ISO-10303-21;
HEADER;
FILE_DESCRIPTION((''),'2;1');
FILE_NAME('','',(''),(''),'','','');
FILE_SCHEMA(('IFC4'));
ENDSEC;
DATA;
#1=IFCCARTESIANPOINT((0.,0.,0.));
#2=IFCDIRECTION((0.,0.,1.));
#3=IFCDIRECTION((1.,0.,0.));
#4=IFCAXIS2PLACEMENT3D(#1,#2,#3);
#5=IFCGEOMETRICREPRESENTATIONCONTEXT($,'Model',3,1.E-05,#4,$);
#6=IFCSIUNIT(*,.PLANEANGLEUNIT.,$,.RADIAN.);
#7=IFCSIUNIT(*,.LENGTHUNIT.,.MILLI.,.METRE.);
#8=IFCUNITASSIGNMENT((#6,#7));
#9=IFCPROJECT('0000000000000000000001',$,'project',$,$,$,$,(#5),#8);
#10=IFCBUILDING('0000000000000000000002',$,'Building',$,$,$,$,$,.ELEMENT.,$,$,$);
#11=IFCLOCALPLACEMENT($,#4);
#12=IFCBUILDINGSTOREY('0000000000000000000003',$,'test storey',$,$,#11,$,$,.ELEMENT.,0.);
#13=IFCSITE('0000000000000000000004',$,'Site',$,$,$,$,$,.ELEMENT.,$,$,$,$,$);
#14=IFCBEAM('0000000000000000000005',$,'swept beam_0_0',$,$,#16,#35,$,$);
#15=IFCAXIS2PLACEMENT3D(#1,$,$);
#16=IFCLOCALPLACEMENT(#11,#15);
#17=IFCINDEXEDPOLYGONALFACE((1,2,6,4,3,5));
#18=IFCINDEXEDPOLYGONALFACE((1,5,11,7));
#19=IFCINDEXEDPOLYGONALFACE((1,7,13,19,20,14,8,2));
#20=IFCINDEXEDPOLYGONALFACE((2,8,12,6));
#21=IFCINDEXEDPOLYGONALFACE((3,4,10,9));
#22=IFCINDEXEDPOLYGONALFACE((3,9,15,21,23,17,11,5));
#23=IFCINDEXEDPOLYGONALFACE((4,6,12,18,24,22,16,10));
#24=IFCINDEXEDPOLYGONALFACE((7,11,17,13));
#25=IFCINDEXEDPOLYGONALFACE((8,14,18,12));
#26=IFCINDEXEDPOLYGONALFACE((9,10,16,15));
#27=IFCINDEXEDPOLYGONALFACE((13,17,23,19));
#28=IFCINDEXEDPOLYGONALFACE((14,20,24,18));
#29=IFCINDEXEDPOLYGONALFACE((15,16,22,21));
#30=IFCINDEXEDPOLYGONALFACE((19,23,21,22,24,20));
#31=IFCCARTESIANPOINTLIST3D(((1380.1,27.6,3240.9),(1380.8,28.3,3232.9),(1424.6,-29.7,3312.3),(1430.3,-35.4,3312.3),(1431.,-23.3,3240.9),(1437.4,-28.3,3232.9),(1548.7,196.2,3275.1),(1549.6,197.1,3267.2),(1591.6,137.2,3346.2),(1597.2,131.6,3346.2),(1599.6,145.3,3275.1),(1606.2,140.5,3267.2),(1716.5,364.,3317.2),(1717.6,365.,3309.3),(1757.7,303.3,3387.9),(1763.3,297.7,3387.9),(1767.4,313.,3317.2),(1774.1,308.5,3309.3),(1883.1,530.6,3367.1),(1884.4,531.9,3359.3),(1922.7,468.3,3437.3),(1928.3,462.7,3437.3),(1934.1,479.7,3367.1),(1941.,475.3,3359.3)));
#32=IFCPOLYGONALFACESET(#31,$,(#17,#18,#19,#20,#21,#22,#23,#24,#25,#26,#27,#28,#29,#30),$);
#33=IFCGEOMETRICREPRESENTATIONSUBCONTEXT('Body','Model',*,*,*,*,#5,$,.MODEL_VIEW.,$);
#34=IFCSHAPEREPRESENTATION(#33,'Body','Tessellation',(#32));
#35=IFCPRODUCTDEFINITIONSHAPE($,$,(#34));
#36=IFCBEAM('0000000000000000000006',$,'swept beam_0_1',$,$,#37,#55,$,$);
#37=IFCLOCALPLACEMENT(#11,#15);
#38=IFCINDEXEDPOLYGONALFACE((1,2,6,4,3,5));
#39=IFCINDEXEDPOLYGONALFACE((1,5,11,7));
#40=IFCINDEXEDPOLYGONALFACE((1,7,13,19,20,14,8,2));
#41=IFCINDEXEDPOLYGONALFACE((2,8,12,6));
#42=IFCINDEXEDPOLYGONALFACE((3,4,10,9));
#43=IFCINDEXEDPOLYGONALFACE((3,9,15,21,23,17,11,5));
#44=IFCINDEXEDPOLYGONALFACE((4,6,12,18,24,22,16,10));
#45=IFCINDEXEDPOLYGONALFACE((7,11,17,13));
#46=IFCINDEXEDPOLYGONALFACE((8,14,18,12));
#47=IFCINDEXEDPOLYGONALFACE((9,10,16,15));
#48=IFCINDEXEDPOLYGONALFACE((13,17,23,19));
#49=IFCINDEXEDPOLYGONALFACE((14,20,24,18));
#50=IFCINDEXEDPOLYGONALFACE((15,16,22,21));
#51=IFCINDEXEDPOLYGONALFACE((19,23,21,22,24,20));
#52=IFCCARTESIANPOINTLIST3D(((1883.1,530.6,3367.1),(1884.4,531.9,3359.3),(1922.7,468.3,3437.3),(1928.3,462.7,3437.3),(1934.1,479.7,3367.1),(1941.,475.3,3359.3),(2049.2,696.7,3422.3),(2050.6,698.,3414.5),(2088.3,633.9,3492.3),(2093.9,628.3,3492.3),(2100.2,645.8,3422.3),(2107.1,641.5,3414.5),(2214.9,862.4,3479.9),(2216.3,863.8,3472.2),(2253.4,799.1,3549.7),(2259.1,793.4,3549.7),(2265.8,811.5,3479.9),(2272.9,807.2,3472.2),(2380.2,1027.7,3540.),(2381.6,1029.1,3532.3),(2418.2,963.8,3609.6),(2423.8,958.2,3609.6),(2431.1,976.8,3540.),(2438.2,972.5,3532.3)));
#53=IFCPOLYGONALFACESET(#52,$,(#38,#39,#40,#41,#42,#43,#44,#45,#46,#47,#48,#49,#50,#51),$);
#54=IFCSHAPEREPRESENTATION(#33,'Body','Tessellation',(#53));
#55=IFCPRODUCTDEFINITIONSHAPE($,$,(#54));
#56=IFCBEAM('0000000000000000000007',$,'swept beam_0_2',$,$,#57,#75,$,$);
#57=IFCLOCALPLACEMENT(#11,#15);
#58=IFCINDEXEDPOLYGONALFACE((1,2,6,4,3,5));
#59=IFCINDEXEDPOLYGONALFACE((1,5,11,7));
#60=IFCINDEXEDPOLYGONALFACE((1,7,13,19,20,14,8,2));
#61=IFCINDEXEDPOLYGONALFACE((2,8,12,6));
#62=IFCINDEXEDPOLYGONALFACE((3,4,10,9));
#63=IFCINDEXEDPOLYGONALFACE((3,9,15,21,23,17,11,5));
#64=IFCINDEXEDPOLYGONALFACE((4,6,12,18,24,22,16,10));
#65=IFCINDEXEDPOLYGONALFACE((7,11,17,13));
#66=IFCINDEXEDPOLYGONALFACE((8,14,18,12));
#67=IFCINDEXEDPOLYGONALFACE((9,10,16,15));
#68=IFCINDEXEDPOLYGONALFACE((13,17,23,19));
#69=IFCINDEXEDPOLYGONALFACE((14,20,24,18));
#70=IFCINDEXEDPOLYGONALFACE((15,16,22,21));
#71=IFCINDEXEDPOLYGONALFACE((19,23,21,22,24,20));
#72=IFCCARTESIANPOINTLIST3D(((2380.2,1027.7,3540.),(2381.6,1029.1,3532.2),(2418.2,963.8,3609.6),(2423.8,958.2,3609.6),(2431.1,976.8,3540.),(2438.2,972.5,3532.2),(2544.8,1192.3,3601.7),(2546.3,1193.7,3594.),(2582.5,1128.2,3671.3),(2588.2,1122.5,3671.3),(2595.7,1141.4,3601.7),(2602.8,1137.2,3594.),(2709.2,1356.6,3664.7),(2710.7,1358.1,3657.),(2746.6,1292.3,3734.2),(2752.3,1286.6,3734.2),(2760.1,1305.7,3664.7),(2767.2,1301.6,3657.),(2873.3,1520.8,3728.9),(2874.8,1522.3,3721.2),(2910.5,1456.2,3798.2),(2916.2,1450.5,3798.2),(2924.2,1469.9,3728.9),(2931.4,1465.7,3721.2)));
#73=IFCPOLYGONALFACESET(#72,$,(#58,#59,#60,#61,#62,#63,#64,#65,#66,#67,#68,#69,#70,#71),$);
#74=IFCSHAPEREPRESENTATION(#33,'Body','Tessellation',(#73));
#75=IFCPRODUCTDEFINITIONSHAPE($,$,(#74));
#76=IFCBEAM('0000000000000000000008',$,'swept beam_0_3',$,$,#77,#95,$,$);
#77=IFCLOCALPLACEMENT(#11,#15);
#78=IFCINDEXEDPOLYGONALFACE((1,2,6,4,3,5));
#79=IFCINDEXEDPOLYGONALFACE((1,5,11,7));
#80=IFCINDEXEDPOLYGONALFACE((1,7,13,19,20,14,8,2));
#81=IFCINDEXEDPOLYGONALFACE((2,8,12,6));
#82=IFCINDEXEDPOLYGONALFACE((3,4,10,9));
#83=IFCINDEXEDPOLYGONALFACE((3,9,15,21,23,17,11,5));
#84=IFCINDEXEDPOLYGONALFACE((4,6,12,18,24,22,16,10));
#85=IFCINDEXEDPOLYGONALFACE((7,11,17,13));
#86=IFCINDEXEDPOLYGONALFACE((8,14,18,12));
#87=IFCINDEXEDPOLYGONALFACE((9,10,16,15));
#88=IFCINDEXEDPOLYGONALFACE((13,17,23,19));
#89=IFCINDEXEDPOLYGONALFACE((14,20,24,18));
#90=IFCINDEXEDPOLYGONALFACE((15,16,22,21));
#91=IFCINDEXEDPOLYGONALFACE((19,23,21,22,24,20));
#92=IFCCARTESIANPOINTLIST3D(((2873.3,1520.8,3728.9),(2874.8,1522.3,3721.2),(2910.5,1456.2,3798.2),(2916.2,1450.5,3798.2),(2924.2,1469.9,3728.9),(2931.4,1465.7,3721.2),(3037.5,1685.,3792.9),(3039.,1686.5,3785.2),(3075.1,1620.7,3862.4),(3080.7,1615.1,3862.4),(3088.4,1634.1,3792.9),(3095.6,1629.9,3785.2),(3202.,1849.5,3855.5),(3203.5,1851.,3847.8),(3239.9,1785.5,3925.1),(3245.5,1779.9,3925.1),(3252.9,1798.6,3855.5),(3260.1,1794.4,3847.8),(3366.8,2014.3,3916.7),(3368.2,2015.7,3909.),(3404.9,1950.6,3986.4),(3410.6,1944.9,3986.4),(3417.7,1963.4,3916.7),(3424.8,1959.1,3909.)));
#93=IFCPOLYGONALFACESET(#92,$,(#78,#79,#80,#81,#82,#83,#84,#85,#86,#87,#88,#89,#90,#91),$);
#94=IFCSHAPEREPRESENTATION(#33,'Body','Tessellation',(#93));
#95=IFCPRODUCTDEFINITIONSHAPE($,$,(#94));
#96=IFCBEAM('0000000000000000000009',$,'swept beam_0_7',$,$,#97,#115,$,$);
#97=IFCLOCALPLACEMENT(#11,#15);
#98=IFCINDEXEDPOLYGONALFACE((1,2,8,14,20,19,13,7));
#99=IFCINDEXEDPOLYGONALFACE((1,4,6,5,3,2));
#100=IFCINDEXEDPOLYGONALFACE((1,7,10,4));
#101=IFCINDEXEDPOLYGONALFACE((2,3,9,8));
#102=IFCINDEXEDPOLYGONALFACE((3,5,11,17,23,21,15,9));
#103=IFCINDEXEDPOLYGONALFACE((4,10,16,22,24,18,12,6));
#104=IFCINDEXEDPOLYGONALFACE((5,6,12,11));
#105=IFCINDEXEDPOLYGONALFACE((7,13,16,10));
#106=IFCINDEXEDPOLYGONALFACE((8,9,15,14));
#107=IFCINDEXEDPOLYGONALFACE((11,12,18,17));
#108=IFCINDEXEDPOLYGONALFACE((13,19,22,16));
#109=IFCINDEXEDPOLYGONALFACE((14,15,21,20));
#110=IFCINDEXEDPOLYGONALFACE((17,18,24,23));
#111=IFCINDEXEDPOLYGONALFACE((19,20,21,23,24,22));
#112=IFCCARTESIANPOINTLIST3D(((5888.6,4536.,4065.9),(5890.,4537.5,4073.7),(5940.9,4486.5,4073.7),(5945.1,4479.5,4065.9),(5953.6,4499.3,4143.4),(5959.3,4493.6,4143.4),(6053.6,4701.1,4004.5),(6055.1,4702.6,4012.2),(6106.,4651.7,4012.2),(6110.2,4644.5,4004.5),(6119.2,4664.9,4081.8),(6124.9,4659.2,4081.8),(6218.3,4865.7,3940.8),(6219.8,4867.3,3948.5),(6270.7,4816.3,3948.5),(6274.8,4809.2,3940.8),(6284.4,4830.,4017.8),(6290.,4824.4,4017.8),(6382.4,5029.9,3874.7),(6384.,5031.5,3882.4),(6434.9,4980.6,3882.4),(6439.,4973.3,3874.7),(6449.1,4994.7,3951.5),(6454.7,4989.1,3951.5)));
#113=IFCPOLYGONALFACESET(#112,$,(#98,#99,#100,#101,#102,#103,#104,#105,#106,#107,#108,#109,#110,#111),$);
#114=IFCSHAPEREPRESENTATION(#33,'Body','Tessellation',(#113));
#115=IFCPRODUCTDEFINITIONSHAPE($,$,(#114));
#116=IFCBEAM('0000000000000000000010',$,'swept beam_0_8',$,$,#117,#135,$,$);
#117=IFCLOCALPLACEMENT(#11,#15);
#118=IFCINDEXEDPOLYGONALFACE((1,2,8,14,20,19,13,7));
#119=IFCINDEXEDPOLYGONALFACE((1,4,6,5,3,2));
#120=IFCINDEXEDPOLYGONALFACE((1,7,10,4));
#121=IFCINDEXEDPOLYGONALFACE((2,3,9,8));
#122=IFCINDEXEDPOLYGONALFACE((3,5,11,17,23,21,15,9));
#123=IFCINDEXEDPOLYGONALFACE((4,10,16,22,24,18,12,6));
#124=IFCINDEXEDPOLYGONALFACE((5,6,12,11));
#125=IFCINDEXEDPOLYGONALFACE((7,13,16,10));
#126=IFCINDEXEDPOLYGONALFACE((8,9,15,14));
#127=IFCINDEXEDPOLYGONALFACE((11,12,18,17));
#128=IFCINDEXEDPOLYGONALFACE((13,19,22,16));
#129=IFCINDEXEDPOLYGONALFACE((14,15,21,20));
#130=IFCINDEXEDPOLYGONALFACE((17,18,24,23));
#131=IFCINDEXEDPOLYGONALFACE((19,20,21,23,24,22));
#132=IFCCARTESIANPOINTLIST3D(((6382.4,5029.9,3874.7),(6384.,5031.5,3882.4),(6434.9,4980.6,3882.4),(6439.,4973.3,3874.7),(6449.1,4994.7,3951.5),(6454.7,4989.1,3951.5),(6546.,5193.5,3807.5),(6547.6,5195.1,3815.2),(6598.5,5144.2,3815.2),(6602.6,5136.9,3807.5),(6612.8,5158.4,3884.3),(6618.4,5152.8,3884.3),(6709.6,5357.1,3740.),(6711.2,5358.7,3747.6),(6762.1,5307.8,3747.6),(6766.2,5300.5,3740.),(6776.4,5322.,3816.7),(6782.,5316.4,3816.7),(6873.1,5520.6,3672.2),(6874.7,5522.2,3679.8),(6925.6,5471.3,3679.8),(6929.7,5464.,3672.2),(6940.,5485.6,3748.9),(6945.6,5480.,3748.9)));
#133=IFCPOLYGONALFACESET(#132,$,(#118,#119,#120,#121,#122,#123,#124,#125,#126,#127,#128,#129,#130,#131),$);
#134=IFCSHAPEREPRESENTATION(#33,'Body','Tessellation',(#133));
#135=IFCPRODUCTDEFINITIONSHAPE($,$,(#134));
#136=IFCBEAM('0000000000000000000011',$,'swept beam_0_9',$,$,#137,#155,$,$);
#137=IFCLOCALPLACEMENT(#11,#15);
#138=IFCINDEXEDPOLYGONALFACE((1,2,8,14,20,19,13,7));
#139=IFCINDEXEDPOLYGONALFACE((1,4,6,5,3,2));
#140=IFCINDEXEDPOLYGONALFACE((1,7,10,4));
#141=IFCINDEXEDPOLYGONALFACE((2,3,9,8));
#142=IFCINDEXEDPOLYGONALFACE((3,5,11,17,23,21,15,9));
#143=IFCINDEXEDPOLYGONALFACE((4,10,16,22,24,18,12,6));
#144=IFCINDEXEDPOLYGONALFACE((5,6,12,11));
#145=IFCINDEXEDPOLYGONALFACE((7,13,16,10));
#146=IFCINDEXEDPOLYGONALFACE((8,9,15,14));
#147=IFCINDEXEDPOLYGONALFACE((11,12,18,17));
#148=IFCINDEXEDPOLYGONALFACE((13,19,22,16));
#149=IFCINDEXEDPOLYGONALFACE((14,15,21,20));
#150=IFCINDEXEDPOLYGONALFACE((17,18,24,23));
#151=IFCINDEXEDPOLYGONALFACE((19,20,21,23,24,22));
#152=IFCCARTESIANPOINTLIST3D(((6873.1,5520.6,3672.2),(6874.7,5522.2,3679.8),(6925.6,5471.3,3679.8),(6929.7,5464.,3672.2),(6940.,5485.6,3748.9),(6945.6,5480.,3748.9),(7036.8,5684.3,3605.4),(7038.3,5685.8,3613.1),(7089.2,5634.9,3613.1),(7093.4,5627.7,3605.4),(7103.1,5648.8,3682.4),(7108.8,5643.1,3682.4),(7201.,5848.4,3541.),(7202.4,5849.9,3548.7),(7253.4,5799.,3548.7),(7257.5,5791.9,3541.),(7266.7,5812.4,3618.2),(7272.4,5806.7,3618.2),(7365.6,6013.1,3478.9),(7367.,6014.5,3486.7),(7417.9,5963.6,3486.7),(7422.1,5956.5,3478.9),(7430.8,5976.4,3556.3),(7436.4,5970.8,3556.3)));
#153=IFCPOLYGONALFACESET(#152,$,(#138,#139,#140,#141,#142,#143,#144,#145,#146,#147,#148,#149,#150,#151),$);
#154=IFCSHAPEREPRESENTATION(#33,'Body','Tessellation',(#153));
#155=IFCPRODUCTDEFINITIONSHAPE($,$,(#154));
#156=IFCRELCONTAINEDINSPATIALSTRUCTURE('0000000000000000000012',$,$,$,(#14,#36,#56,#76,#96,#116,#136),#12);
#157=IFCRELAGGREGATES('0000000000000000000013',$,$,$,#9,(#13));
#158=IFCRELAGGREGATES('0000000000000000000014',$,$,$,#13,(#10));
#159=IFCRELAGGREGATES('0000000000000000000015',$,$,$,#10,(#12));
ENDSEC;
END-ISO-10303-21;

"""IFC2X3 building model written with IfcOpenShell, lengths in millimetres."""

from ifc_helpers import new_model, entity, si_unit, origin_with_axes, place, context, subcontext, project, spatial, element, save


model = new_model("IFC2X3")

# Units and contexts
model_context = context("Model", 3, precision=1e-05, world=origin_with_axes())
body_context = subcontext(model_context, "Body", "Model", "MODEL_VIEW")
ifc_project = project(units=[si_unit("PLANEANGLEUNIT", "RADIAN"), si_unit("LENGTHUNIT", "METRE", prefix="MILLI")], contexts=[model_context])

# Site, building, storey
site = spatial("IfcSite", under=ifc_project, Name="Site", CompositionType="ELEMENT")
building = spatial("IfcBuilding", under=site, Name="Building", CompositionType="ELEMENT")
storey_placement = place(None, origin_with_axes())
storey = spatial("IfcBuildingStorey", under=building, at=storey_placement, Name="test storey", CompositionType="ELEMENT", Elevation=0.0)

# Beams
beam_1_placement = place(storey_placement, origin_with_axes())
element("IfcBeam", 1, at=beam_1_placement, inside=storey, Name="swept beam_0_0", context=body_context, shape_type="SweptSolid", body=[
    entity("IfcRevolvedAreaSolid", entity("IfcArbitraryClosedProfileDef", "AREA", None, entity("IfcPolyline", [entity("IfcCartesianPoint", [-80.0, 40.0]), entity("IfcCartesianPoint", [-80.0, 32.0]), entity("IfcCartesianPoint", [-8.0, 32.0]), entity("IfcCartesianPoint", [-8.0, -40.0]), entity("IfcCartesianPoint", [0.0, -40.0]), entity("IfcCartesianPoint", [0.0, 40.0]), entity("IfcCartesianPoint", [-80.0, 40.0])])), entity("IfcAxis2Placement3D", entity("IfcCartesianPoint", [1409.1, 0.0, 3232.9]), entity("IfcDirection", [-0.7015, -0.7015, -0.1256]), entity("IfcDirection", [0.0888, 0.0888, -0.9921])), entity("IfcAxis1Placement", entity("IfcCartesianPoint", [-7275.5, 0.0, 0.0]), entity("IfcDirection", [0.0, 1.0, 0.0])), 0.099461),
])
beam_2_placement = place(storey_placement, origin_with_axes())
element("IfcBeam", 2, at=beam_2_placement, inside=storey, Name="swept beam_0_1", context=body_context, shape_type="SweptSolid", body=[
    entity("IfcRevolvedAreaSolid", entity("IfcArbitraryClosedProfileDef", "AREA", None, entity("IfcPolyline", [entity("IfcCartesianPoint", [-80.0, 40.0]), entity("IfcCartesianPoint", [-80.0, 32.0]), entity("IfcCartesianPoint", [-8.0, 32.0]), entity("IfcCartesianPoint", [-8.0, -40.0]), entity("IfcCartesianPoint", [0.0, -40.0]), entity("IfcCartesianPoint", [0.0, 40.0]), entity("IfcCartesianPoint", [-80.0, 40.0])])), entity("IfcAxis2Placement3D", entity("IfcCartesianPoint", [1912.7, 503.6, 3359.3]), entity("IfcDirection", [-0.6892, -0.6892, -0.2235]), entity("IfcDirection", [0.158, 0.158, -0.9747])), entity("IfcAxis1Placement", entity("IfcCartesianPoint", [-23039.6, 0.0, 0.0]), entity("IfcDirection", [0.0, 1.0, 0.0])), 0.031431),
])
beam_3_placement = place(storey_placement, origin_with_axes())
element("IfcBeam", 3, at=beam_3_placement, inside=storey, Name="swept beam_0_2", context=body_context, shape_type="SweptSolid", body=[
    entity("IfcRevolvedAreaSolid", entity("IfcArbitraryClosedProfileDef", "AREA", None, entity("IfcPolyline", [entity("IfcCartesianPoint", [-80.0, 40.0]), entity("IfcCartesianPoint", [-80.0, 32.0]), entity("IfcCartesianPoint", [-8.0, 32.0]), entity("IfcCartesianPoint", [-8.0, -40.0]), entity("IfcCartesianPoint", [0.0, -40.0]), entity("IfcCartesianPoint", [0.0, 40.0]), entity("IfcCartesianPoint", [-80.0, 40.0])])), entity("IfcAxis2Placement3D", entity("IfcCartesianPoint", [2409.9, 1000.8, 3532.2]), entity("IfcDirection", [-0.6839, -0.6839, -0.254]), entity("IfcDirection", [0.1796, 0.1796, -0.9672])), entity("IfcAxis1Placement", entity("IfcCartesianPoint", [-47016.9, 0.0, 0.0]), entity("IfcDirection", [0.0, 1.0, 0.0])), 0.015369),
])
beam_4_placement = place(storey_placement, origin_with_axes())
element("IfcBeam", 4, at=beam_4_placement, inside=storey, Name="swept beam_0_3", context=body_context, shape_type="SweptSolid", body=[
    entity("IfcRevolvedAreaSolid", entity("IfcArbitraryClosedProfileDef", "AREA", None, entity("IfcPolyline", [entity("IfcCartesianPoint", [80.0, -40.0]), entity("IfcCartesianPoint", [80.0, -32.0]), entity("IfcCartesianPoint", [8.0, -32.0]), entity("IfcCartesianPoint", [8.0, 40.0]), entity("IfcCartesianPoint", [0.0, 40.0]), entity("IfcCartesianPoint", [0.0, -40.0]), entity("IfcCartesianPoint", [80.0, -40.0])])), entity("IfcAxis2Placement3D", entity("IfcCartesianPoint", [2903.1, 1494.0, 3721.2]), entity("IfcDirection", [-0.6811, -0.6811, -0.2688]), entity("IfcDirection", [-0.1901, -0.1901, 0.9632])), entity("IfcAxis1Placement", entity("IfcCartesianPoint", [-39422.9, 0.0, 0.0]), entity("IfcDirection", [0.0, 1.0, 0.0])), 0.01833),
])
beam_5_placement = place(storey_placement, origin_with_axes())
element("IfcBeam", 5, at=beam_5_placement, inside=storey, Name="swept beam_0_7", context=body_context, shape_type="SweptSolid", body=[
    entity("IfcRevolvedAreaSolid", entity("IfcArbitraryClosedProfileDef", "AREA", None, entity("IfcPolyline", [entity("IfcCartesianPoint", [80.0, -40.0]), entity("IfcCartesianPoint", [80.0, -32.0]), entity("IfcCartesianPoint", [8.0, -32.0]), entity("IfcCartesianPoint", [8.0, 40.0]), entity("IfcCartesianPoint", [0.0, 40.0]), entity("IfcCartesianPoint", [0.0, -40.0]), entity("IfcCartesianPoint", [80.0, -40.0])])), entity("IfcAxis2Placement3D", entity("IfcCartesianPoint", [5916.8, 4507.8, 4065.9]), entity("IfcDirection", [-0.6847, -0.6847, 0.2497]), entity("IfcDirection", [0.1766, 0.1766, 0.9683])), entity("IfcAxis1Placement", entity("IfcCartesianPoint", [-24332.1, 0.0, 0.0]), entity("IfcDirection", [0.0, 1.0, 0.0])), 0.029762),
])
beam_6_placement = place(storey_placement, origin_with_axes())
element("IfcBeam", 6, at=beam_6_placement, inside=storey, Name="swept beam_0_8", context=body_context, shape_type="SweptSolid", body=[
    entity("IfcRevolvedAreaSolid", entity("IfcArbitraryClosedProfileDef", "AREA", None, entity("IfcPolyline", [entity("IfcCartesianPoint", [80.0, -40.0]), entity("IfcCartesianPoint", [80.0, -32.0]), entity("IfcCartesianPoint", [8.0, -32.0]), entity("IfcCartesianPoint", [8.0, 40.0]), entity("IfcCartesianPoint", [0.0, 40.0]), entity("IfcCartesianPoint", [0.0, -40.0]), entity("IfcCartesianPoint", [80.0, -40.0])])), entity("IfcAxis2Placement3D", entity("IfcCartesianPoint", [6410.7, 5001.6, 3874.7]), entity("IfcDirection", [-0.6791, -0.6791, 0.2784]), entity("IfcDirection", [0.1969, 0.1969, 0.9605])), entity("IfcAxis1Placement", entity("IfcCartesianPoint", [-196255.0, 0.0, 0.0]), entity("IfcDirection", [0.0, 1.0, 0.0])), 0.003683),
])
beam_7_placement = place(storey_placement, origin_with_axes())
element("IfcBeam", 7, at=beam_7_placement, inside=storey, Name="swept beam_0_9", context=body_context, shape_type="SweptSolid", body=[
    entity("IfcRevolvedAreaSolid", entity("IfcArbitraryClosedProfileDef", "AREA", None, entity("IfcPolyline", [entity("IfcCartesianPoint", [-80.0, 40.0]), entity("IfcCartesianPoint", [-80.0, 32.0]), entity("IfcCartesianPoint", [-8.0, 32.0]), entity("IfcCartesianPoint", [-8.0, -40.0]), entity("IfcCartesianPoint", [0.0, -40.0]), entity("IfcCartesianPoint", [0.0, 40.0]), entity("IfcCartesianPoint", [-80.0, 40.0])])), entity("IfcAxis2Placement3D", entity("IfcCartesianPoint", [6901.4, 5492.3, 3672.2]), entity("IfcDirection", [-0.6784, -0.6784, 0.2819]), entity("IfcDirection", [-0.1994, -0.1994, -0.9594])), entity("IfcAxis1Placement", entity("IfcCartesianPoint", [-23876.7, 0.0, 0.0]), entity("IfcDirection", [0.0, 1.0, 0.0])), 0.030273),
])

save(model, "model.ifc")
